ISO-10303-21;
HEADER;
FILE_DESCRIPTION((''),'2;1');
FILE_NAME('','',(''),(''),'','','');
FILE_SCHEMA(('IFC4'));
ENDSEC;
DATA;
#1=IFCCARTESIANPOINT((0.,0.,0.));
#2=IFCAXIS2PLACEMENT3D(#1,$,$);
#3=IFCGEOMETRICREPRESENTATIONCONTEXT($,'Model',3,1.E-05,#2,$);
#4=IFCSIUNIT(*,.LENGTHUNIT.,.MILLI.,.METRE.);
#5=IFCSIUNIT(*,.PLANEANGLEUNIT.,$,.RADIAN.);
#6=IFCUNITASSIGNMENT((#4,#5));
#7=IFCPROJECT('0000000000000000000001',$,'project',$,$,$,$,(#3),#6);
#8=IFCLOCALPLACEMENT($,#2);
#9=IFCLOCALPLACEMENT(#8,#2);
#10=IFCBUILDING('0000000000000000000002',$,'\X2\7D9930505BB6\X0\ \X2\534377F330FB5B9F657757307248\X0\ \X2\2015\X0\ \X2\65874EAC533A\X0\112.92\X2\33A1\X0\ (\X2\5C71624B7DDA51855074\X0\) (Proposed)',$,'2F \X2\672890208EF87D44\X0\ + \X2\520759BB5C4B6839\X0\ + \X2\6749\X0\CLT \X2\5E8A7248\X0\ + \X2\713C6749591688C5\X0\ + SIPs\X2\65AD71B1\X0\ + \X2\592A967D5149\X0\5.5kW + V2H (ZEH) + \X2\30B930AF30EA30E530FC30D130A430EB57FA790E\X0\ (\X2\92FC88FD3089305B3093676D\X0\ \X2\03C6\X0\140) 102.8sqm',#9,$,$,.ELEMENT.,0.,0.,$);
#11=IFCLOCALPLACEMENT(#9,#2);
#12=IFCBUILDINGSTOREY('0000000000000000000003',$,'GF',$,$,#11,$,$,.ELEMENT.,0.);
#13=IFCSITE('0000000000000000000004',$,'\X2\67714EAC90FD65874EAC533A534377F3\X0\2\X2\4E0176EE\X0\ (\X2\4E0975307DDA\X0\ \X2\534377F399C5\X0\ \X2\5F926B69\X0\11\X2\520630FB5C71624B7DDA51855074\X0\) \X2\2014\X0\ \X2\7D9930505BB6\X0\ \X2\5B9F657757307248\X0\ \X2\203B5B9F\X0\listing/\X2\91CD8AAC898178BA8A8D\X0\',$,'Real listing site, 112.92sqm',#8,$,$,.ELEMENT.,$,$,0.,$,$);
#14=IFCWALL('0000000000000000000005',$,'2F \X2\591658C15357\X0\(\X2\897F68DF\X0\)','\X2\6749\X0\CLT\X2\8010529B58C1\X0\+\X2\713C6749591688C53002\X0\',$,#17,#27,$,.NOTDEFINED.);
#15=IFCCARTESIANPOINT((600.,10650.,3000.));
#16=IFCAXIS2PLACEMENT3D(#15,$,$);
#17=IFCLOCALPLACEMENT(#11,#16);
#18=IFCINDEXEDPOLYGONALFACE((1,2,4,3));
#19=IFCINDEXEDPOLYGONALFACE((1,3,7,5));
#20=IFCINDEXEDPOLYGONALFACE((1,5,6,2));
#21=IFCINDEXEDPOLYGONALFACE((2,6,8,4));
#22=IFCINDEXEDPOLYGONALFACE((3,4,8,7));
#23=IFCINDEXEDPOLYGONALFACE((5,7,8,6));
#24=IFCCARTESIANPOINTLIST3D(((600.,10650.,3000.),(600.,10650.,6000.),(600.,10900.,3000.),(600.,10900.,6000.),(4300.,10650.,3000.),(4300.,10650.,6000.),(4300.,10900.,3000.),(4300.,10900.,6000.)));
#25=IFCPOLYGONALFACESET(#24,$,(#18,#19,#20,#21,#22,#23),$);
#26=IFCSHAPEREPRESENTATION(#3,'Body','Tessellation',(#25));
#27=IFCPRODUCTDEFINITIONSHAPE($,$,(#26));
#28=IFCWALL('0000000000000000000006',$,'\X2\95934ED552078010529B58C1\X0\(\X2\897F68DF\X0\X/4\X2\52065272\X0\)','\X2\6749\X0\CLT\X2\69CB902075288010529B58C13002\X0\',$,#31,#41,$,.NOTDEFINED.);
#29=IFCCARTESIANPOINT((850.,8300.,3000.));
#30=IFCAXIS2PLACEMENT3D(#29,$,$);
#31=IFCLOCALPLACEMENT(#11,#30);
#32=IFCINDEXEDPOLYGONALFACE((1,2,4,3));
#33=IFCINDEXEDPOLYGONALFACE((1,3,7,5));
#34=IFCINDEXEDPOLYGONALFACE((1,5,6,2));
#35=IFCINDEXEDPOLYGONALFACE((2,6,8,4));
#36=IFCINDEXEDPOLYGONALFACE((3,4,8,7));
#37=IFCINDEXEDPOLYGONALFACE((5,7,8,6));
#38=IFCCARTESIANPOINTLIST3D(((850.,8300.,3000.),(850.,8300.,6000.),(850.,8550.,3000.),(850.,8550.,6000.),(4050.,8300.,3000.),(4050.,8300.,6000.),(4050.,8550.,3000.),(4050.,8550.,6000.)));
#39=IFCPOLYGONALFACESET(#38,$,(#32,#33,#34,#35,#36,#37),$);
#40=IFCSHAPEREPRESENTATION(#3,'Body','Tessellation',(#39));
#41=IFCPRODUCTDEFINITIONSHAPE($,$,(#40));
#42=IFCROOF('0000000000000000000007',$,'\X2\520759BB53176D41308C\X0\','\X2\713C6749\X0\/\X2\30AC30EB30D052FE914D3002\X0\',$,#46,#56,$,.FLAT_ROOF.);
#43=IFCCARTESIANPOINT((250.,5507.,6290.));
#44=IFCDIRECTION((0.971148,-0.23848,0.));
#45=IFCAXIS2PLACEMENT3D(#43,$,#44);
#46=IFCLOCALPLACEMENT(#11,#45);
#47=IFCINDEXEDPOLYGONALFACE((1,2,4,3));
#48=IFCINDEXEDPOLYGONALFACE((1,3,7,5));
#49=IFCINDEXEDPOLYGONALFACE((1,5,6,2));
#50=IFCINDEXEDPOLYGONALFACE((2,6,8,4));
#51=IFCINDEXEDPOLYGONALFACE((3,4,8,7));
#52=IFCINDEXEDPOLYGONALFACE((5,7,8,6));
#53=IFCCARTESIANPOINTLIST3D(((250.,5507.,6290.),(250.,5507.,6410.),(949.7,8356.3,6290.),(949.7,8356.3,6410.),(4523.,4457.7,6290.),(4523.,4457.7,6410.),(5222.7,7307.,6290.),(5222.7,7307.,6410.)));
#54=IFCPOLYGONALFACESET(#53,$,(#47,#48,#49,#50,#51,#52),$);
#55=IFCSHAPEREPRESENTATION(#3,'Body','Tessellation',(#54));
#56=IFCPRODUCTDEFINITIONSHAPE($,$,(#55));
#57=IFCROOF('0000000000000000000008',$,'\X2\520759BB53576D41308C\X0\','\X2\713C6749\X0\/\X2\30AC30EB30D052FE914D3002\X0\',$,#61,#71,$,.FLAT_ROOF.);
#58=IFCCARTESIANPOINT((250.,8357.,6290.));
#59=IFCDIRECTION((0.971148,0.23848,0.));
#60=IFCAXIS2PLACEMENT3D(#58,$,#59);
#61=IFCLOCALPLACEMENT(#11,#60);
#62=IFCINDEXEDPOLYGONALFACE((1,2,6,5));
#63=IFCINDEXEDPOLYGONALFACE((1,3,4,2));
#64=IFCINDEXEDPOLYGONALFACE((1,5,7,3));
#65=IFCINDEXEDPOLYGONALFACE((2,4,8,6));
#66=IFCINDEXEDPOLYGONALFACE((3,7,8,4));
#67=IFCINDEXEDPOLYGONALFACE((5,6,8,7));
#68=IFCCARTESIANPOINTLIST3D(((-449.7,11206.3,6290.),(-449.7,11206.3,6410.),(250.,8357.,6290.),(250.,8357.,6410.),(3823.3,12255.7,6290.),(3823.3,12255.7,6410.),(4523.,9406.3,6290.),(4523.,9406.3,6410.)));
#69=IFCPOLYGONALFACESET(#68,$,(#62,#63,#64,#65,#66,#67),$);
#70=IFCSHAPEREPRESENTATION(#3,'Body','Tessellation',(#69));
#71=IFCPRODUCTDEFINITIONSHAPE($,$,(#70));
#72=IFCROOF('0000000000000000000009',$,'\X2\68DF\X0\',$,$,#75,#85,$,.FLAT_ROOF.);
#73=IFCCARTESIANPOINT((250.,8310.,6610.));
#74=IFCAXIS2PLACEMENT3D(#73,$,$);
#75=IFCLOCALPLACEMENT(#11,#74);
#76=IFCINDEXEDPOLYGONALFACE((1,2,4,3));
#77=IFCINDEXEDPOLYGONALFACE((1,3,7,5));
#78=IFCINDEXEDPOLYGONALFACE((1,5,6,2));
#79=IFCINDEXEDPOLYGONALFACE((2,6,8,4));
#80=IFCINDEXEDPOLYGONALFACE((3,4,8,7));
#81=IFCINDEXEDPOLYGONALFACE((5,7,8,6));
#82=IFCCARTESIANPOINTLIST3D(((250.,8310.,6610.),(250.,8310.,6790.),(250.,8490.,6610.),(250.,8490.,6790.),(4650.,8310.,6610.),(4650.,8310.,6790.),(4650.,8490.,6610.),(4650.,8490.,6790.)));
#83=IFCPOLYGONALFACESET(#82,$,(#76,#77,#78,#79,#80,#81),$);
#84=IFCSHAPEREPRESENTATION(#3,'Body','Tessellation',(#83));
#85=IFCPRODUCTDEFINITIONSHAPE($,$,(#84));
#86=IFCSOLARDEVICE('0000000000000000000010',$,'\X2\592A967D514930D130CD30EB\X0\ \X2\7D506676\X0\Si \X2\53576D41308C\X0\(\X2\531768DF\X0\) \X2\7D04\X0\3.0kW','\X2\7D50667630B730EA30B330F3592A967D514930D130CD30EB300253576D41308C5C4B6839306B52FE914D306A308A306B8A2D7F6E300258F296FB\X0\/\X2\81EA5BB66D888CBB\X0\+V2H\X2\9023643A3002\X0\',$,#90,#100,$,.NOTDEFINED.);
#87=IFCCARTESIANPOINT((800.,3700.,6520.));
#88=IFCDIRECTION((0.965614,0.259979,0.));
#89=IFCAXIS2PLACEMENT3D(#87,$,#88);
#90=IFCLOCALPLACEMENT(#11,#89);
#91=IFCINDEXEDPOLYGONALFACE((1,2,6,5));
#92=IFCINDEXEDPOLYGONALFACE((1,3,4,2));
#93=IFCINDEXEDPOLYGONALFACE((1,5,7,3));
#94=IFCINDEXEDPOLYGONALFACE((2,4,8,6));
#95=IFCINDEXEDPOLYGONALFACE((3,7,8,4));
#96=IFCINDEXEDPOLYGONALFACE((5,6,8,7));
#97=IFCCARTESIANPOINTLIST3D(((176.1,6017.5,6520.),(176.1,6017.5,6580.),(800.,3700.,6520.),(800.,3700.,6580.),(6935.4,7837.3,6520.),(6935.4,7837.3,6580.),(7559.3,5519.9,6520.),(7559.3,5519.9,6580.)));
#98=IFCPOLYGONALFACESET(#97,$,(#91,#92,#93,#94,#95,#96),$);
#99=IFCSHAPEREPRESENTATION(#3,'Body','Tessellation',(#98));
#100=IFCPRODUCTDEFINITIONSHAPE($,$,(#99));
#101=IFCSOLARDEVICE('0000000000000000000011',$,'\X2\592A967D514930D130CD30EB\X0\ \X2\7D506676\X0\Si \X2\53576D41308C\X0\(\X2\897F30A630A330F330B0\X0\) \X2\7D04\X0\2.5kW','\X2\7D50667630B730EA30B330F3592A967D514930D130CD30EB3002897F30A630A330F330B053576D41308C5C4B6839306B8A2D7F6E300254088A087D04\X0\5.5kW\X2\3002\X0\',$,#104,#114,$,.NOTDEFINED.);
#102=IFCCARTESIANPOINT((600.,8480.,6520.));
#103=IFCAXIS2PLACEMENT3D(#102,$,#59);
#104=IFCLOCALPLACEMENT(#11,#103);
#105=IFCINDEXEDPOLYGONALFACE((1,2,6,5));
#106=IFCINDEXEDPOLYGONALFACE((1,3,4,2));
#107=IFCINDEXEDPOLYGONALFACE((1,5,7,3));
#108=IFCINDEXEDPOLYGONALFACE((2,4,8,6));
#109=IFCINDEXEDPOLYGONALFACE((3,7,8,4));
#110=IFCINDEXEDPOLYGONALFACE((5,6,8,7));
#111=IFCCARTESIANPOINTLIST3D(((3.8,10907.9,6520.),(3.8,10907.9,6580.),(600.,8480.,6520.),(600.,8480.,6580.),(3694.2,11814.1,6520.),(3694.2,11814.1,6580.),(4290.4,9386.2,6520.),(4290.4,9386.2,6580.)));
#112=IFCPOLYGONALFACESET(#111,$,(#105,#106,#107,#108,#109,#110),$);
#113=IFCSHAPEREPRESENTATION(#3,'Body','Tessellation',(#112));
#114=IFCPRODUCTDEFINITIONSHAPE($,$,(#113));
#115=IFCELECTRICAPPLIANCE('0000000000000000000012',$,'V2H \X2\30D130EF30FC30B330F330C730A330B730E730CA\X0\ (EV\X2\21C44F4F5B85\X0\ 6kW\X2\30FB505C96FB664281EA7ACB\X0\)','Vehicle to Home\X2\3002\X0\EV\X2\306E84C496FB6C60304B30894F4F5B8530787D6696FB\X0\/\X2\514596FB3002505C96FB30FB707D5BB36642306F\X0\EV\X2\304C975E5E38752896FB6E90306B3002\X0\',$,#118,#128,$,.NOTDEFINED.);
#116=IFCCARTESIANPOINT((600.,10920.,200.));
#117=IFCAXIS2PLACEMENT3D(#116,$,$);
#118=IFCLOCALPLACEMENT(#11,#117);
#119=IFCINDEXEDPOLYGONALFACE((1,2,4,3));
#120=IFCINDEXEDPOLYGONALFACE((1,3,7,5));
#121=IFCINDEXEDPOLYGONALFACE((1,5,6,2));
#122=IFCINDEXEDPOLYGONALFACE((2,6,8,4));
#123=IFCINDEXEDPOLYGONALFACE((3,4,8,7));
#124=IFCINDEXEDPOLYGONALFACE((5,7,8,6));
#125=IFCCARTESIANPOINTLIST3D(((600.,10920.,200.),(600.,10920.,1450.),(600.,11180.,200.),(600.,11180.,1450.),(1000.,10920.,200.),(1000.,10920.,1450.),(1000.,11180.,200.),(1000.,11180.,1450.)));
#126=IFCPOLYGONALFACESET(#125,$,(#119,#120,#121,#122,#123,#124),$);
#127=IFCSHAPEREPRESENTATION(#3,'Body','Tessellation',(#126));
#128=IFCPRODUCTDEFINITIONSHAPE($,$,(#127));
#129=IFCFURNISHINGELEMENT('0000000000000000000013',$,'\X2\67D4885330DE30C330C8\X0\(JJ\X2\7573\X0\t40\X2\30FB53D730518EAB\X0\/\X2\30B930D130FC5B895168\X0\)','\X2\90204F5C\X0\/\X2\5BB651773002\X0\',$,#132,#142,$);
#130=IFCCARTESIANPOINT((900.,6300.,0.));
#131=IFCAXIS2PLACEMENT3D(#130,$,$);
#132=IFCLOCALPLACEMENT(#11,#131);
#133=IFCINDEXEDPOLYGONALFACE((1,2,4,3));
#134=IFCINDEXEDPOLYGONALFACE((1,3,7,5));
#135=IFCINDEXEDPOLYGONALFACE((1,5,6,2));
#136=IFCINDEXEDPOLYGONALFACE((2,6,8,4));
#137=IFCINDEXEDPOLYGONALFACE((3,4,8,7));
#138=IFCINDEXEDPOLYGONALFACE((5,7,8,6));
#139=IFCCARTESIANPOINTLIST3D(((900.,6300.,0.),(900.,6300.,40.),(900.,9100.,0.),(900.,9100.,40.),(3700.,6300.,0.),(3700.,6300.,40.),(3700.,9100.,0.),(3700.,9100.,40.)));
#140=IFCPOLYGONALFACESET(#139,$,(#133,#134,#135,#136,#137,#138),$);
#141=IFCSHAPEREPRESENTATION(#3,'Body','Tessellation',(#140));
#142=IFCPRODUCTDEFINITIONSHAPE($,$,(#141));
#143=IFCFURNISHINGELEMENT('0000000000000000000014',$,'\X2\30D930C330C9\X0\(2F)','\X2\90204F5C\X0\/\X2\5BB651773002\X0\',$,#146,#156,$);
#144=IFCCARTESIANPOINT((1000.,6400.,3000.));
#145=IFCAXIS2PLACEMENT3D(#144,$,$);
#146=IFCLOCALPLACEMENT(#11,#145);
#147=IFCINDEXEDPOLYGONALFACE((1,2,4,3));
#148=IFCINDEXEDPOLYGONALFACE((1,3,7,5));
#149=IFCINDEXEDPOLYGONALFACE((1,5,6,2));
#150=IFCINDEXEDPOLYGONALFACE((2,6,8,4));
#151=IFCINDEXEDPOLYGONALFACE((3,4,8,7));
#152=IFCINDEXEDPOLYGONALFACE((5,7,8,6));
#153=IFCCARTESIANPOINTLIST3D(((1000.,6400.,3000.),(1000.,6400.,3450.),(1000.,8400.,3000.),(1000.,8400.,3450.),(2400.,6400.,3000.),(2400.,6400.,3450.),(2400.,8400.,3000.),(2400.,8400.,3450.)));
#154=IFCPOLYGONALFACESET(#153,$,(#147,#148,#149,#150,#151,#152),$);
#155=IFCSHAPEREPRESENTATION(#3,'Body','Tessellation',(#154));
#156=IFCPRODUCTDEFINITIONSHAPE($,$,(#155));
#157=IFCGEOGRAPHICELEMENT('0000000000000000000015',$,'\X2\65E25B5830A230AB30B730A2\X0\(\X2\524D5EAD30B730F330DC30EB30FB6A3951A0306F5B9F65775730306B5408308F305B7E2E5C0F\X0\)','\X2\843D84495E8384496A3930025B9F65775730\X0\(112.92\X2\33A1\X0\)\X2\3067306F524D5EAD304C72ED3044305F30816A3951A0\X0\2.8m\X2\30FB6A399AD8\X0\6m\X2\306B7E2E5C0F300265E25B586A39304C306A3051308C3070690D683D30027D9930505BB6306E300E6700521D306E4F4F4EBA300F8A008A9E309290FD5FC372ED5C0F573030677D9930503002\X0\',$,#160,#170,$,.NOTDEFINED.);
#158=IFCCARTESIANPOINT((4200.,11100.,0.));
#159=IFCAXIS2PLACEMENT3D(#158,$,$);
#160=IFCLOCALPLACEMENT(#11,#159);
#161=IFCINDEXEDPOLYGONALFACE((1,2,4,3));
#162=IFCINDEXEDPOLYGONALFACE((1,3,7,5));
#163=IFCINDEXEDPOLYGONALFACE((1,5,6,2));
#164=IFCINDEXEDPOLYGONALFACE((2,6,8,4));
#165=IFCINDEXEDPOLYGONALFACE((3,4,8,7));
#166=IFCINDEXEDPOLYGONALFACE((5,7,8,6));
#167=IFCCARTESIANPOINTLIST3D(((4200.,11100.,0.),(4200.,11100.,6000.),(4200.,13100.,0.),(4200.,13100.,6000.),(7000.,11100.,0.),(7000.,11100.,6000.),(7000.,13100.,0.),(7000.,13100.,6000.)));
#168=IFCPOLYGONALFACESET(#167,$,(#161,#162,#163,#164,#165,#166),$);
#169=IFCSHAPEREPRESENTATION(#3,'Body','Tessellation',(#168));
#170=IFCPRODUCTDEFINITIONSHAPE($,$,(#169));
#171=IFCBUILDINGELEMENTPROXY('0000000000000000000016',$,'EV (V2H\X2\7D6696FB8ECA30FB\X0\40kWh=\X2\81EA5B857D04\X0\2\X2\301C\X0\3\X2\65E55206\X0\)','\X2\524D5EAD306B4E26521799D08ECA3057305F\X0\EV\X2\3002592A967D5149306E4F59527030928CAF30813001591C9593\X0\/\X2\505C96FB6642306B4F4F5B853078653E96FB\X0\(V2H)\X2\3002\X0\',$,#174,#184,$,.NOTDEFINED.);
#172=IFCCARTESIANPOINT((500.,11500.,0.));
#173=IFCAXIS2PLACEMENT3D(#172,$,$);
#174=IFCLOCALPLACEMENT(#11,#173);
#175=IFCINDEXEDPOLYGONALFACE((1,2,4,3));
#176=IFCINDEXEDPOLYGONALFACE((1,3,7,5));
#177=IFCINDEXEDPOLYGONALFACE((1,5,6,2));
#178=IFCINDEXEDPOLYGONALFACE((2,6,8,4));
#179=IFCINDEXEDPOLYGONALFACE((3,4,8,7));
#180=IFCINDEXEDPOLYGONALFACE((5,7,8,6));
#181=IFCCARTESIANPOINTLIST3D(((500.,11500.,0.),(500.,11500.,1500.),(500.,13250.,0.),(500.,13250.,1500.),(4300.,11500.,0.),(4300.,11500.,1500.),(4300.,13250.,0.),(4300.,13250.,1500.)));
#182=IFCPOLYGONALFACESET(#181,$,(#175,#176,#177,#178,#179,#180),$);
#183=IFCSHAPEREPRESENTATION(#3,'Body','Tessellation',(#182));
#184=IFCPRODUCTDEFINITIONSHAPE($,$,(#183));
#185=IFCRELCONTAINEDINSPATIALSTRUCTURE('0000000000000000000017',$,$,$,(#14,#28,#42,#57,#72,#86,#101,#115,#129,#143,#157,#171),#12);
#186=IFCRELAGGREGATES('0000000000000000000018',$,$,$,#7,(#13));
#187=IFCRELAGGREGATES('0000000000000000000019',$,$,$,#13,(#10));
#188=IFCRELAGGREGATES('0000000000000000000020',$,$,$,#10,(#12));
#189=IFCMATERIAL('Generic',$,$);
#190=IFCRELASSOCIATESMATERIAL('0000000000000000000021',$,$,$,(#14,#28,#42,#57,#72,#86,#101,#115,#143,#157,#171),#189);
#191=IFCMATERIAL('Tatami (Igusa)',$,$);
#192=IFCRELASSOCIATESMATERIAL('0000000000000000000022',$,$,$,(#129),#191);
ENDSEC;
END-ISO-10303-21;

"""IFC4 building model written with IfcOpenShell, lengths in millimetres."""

from ifc_helpers import new_model, si_unit, frame, frame_2d, origin, place, context, project, spatial, rectangle, extrude, material, element, save


model = new_model("IFC4")

# Units and contexts
model_context = context("Model", 3, precision=1e-05, world=origin())
ifc_project = project(units=[si_unit("LENGTHUNIT", "METRE", prefix="MILLI"), si_unit("PLANEANGLEUNIT", "RADIAN")], contexts=[model_context])

# Site, building, storey
site_placement = place(None, origin())
site = spatial("IfcSite", under=ifc_project, at=site_placement, Name="東京都文京区千石2丁目 (三田線 千石駅 徒歩11分・山手線内側) — 継ぐ家 実敷地版 ※実listing/重説要確認", ObjectType="Real listing site, 112.92sqm", CompositionType="ELEMENT", RefElevation=0.0)
building_placement = place(site_placement, origin())
building = spatial("IfcBuilding", under=site, at=building_placement, Name="継ぐ家 千石・実敷地版 ― 文京区112.92㎡ (山手線内側) (Proposed)", ObjectType="2F 木造軸組 + 切妻屋根 + 杉CLT 床版 + 焼杉外装 + SIPs断熱 + 太陽光5.5kW + V2H (ZEH) + スクリューパイル基礎 (鋼製らせん杭 φ140) 102.8sqm", CompositionType="ELEMENT", ElevationOfRefHeight=0.0, ElevationOfTerrain=0.0)
storey_placement = place(building_placement, origin())
storey = spatial("IfcBuildingStorey", under=building, at=storey_placement, Name="GF", CompositionType="ELEMENT", Elevation=0.0)

# Shared definitions
ifc_material_1 = material(Name="Generic")

# Walls
wall_1_placement = place(storey_placement, frame((600.0, 10650.0, 3000.0)))
element("IfcWall", 1, at=wall_1_placement, inside=storey, material=ifc_material_1, Name="2F 外壁南(西棟)", Description="杉CLT耐力壁+焼杉外装。", PredefinedType="NOTDEFINED", context=model_context, shape_type="SweptSolid", body=[
    extrude(rectangle(XDim=3700.0, YDim=250.0, at=frame_2d((1850.0, 125.0))), frame((600.0, 10650.0, 3000.0)), (0.0, 0.0, 1.0), 3000.0),
])
wall_2_placement = place(storey_placement, frame((850.0, 8300.0, 3000.0)))
element("IfcWall", 2, at=wall_2_placement, inside=storey, material=ifc_material_1, Name="間仕切耐力壁(西棟X/4分割)", Description="杉CLT構造用耐力壁。", PredefinedType="NOTDEFINED", context=model_context, shape_type="SweptSolid", body=[
    extrude(rectangle(XDim=3200.0, YDim=250.0, at=frame_2d((1600.0, 125.0))), frame((850.0, 8300.0, 3000.0)), (0.0, 0.0, 1.0), 3000.0),
])

# Roofs
roof_1_placement = place(storey_placement, frame((250.0, 5507.0, 6290.0), x_axis=(0.971148, -0.23848, 0.0)))
element("IfcRoof", 3, at=roof_1_placement, inside=storey, material=ifc_material_1, Name="切妻北流れ", Description="焼杉/ガルバ勾配。", PredefinedType="FLAT_ROOF", context=model_context, shape_type="SweptSolid", body=[
    extrude(rectangle(XDim=4400.0, YDim=2934.0, at=frame_2d((2200.0, 1467.0))), frame((250.0, 5507.0, 6290.0), x_axis=(0.971148, -0.23848, 0.0)), (0.0, 0.0, 1.0), 120.0),
])
roof_2_placement = place(storey_placement, frame((250.0, 8357.0, 6290.0), x_axis=(0.971148, 0.23848, 0.0)))
element("IfcRoof", 4, at=roof_2_placement, inside=storey, material=ifc_material_1, Name="切妻南流れ", Description="焼杉/ガルバ勾配。", PredefinedType="FLAT_ROOF", context=model_context, shape_type="SweptSolid", body=[
    extrude(rectangle(XDim=4400.0, YDim=2934.0, at=frame_2d((2200.0, 1467.0))), frame((250.0, 8357.0, 6290.0), x_axis=(0.971148, 0.23848, 0.0)), (0.0, 0.0, 1.0), 120.0),
])
roof_3_placement = place(storey_placement, frame((250.0, 8310.0, 6610.0)))
element("IfcRoof", 5, at=roof_3_placement, inside=storey, material=ifc_material_1, Name="棟", PredefinedType="FLAT_ROOF", context=model_context, shape_type="SweptSolid", body=[
    extrude(rectangle(XDim=4400.0, YDim=180.0, at=frame_2d((2200.0, 90.0))), frame((250.0, 8310.0, 6610.0)), (0.0, 0.0, 1.0), 180.0),
])

# Solar devices
solar_device_1_placement = place(storey_placement, frame((800.0, 3700.0, 6520.0), x_axis=(0.965614, 0.259979, 0.0)))
element("IfcSolarDevice", 6, at=solar_device_1_placement, inside=storey, material=ifc_material_1, Name="太陽光パネル 結晶Si 南流れ(北棟) 約3.0kW", Description="結晶シリコン太陽光パネル。南流れ屋根に勾配なりに設置。売電/自家消費+V2H連携。", PredefinedType="NOTDEFINED", context=model_context, shape_type="SweptSolid", body=[
    extrude(rectangle(XDim=7000.0, YDim=2400.0, at=frame_2d((3500.0, 1200.0))), frame((800.0, 3700.0, 6520.0), x_axis=(0.965614, 0.259979, 0.0)), (0.0, 0.0, 1.0), 60.0),
])
solar_device_2_placement = place(storey_placement, frame((600.0, 8480.0, 6520.0), x_axis=(0.971148, 0.23848, 0.0)))
element("IfcSolarDevice", 7, at=solar_device_2_placement, inside=storey, material=ifc_material_1, Name="太陽光パネル 結晶Si 南流れ(西ウィング) 約2.5kW", Description="結晶シリコン太陽光パネル。西ウィング南流れ屋根に設置。合計約5.5kW。", PredefinedType="NOTDEFINED", context=model_context, shape_type="SweptSolid", body=[
    extrude(rectangle(XDim=3800.0, YDim=2500.0, at=frame_2d((1900.0, 1250.0))), frame((600.0, 8480.0, 6520.0), x_axis=(0.971148, 0.23848, 0.0)), (0.0, 0.0, 1.0), 60.0),
])

# Electric appliance
electric_appliance_placement = place(storey_placement, frame((600.0, 10920.0, 200.0)))
element("IfcElectricAppliance", 8, at=electric_appliance_placement, inside=storey, material=ifc_material_1, Name="V2H パワーコンディショナ (EV⇄住宅 6kW・停電時自立)", Description="Vehicle to Home。EVの蓄電池から住宅へ給電/充電。停電・災害時はEVが非常用電源に。", PredefinedType="NOTDEFINED", context=model_context, shape_type="SweptSolid", body=[
    extrude(rectangle(XDim=400.0, YDim=260.0, at=frame_2d((200.0, 130.0))), frame((600.0, 10920.0, 200.0)), (0.0, 0.0, 1.0), 1250.0),
])

# Furnishing elements
ifc_material_2 = material(Name="Tatami (Igusa)")
furnishing_1_placement = place(storey_placement, frame((900.0, 6300.0, 0.0)))
element("IfcFurnishingElement", 9, at=furnishing_1_placement, inside=storey, material=ifc_material_2, Name="柔術マット(JJ畳t40・受け身/スパー安全)", Description="造作/家具。", context=model_context, shape_type="SweptSolid", body=[
    extrude(rectangle(XDim=2800.0, YDim=2800.0, at=frame_2d((1400.0, 1400.0))), frame((900.0, 6300.0, 0.0)), (0.0, 0.0, 1.0), 40.0),
])
furnishing_2_placement = place(storey_placement, frame((1000.0, 6400.0, 3000.0)))
element("IfcFurnishingElement", 10, at=furnishing_2_placement, inside=storey, material=ifc_material_1, Name="ベッド(2F)", Description="造作/家具。", context=model_context, shape_type="SweptSolid", body=[
    extrude(rectangle(XDim=1400.0, YDim=2000.0, at=frame_2d((700.0, 1000.0))), frame((1000.0, 6400.0, 3000.0)), (0.0, 0.0, 1.0), 450.0),
])

# Geographic element
geographic_element_placement = place(storey_placement, frame((4200.0, 11100.0, 0.0)))
element("IfcGeographicElement", 11, at=geographic_element_placement, inside=storey, material=ifc_material_1, Name="既存アカシア(前庭シンボル・樹冠は実敷地に合わせ縮小)", Description="落葉広葉樹。実敷地(112.92㎡)では前庭が狭いため樹冠2.8m・樹高6mに縮小。既存樹がなければ植栽。継ぐ家の『最初の住人』言語を都心狭小地で継ぐ。", PredefinedType="NOTDEFINED", context=model_context, shape_type="SweptSolid", body=[
    extrude(rectangle(XDim=2800.0, YDim=2000.0, at=frame_2d((1400.0, 1000.0))), frame((4200.0, 11100.0, 0.0)), (0.0, 0.0, 1.0), 6000.0),
])

# Building element proxy
proxy_placement = place(storey_placement, frame((500.0, 11500.0, 0.0)))
element("IfcBuildingElementProxy", 12, at=proxy_placement, inside=storey, material=ifc_material_1, Name="EV (V2H給電車・40kWh=自宅約2〜3日分)", Description="前庭に並列駐車したEV。太陽光の余剰を貯め、夜間/停電時に住宅へ放電(V2H)。", PredefinedType="NOTDEFINED", context=model_context, shape_type="SweptSolid", body=[
    extrude(rectangle(XDim=3800.0, YDim=1750.0, at=frame_2d((1900.0, 875.0))), frame((500.0, 11500.0, 0.0)), (0.0, 0.0, 1.0), 1500.0),
])

save(model, "model.ifc")
